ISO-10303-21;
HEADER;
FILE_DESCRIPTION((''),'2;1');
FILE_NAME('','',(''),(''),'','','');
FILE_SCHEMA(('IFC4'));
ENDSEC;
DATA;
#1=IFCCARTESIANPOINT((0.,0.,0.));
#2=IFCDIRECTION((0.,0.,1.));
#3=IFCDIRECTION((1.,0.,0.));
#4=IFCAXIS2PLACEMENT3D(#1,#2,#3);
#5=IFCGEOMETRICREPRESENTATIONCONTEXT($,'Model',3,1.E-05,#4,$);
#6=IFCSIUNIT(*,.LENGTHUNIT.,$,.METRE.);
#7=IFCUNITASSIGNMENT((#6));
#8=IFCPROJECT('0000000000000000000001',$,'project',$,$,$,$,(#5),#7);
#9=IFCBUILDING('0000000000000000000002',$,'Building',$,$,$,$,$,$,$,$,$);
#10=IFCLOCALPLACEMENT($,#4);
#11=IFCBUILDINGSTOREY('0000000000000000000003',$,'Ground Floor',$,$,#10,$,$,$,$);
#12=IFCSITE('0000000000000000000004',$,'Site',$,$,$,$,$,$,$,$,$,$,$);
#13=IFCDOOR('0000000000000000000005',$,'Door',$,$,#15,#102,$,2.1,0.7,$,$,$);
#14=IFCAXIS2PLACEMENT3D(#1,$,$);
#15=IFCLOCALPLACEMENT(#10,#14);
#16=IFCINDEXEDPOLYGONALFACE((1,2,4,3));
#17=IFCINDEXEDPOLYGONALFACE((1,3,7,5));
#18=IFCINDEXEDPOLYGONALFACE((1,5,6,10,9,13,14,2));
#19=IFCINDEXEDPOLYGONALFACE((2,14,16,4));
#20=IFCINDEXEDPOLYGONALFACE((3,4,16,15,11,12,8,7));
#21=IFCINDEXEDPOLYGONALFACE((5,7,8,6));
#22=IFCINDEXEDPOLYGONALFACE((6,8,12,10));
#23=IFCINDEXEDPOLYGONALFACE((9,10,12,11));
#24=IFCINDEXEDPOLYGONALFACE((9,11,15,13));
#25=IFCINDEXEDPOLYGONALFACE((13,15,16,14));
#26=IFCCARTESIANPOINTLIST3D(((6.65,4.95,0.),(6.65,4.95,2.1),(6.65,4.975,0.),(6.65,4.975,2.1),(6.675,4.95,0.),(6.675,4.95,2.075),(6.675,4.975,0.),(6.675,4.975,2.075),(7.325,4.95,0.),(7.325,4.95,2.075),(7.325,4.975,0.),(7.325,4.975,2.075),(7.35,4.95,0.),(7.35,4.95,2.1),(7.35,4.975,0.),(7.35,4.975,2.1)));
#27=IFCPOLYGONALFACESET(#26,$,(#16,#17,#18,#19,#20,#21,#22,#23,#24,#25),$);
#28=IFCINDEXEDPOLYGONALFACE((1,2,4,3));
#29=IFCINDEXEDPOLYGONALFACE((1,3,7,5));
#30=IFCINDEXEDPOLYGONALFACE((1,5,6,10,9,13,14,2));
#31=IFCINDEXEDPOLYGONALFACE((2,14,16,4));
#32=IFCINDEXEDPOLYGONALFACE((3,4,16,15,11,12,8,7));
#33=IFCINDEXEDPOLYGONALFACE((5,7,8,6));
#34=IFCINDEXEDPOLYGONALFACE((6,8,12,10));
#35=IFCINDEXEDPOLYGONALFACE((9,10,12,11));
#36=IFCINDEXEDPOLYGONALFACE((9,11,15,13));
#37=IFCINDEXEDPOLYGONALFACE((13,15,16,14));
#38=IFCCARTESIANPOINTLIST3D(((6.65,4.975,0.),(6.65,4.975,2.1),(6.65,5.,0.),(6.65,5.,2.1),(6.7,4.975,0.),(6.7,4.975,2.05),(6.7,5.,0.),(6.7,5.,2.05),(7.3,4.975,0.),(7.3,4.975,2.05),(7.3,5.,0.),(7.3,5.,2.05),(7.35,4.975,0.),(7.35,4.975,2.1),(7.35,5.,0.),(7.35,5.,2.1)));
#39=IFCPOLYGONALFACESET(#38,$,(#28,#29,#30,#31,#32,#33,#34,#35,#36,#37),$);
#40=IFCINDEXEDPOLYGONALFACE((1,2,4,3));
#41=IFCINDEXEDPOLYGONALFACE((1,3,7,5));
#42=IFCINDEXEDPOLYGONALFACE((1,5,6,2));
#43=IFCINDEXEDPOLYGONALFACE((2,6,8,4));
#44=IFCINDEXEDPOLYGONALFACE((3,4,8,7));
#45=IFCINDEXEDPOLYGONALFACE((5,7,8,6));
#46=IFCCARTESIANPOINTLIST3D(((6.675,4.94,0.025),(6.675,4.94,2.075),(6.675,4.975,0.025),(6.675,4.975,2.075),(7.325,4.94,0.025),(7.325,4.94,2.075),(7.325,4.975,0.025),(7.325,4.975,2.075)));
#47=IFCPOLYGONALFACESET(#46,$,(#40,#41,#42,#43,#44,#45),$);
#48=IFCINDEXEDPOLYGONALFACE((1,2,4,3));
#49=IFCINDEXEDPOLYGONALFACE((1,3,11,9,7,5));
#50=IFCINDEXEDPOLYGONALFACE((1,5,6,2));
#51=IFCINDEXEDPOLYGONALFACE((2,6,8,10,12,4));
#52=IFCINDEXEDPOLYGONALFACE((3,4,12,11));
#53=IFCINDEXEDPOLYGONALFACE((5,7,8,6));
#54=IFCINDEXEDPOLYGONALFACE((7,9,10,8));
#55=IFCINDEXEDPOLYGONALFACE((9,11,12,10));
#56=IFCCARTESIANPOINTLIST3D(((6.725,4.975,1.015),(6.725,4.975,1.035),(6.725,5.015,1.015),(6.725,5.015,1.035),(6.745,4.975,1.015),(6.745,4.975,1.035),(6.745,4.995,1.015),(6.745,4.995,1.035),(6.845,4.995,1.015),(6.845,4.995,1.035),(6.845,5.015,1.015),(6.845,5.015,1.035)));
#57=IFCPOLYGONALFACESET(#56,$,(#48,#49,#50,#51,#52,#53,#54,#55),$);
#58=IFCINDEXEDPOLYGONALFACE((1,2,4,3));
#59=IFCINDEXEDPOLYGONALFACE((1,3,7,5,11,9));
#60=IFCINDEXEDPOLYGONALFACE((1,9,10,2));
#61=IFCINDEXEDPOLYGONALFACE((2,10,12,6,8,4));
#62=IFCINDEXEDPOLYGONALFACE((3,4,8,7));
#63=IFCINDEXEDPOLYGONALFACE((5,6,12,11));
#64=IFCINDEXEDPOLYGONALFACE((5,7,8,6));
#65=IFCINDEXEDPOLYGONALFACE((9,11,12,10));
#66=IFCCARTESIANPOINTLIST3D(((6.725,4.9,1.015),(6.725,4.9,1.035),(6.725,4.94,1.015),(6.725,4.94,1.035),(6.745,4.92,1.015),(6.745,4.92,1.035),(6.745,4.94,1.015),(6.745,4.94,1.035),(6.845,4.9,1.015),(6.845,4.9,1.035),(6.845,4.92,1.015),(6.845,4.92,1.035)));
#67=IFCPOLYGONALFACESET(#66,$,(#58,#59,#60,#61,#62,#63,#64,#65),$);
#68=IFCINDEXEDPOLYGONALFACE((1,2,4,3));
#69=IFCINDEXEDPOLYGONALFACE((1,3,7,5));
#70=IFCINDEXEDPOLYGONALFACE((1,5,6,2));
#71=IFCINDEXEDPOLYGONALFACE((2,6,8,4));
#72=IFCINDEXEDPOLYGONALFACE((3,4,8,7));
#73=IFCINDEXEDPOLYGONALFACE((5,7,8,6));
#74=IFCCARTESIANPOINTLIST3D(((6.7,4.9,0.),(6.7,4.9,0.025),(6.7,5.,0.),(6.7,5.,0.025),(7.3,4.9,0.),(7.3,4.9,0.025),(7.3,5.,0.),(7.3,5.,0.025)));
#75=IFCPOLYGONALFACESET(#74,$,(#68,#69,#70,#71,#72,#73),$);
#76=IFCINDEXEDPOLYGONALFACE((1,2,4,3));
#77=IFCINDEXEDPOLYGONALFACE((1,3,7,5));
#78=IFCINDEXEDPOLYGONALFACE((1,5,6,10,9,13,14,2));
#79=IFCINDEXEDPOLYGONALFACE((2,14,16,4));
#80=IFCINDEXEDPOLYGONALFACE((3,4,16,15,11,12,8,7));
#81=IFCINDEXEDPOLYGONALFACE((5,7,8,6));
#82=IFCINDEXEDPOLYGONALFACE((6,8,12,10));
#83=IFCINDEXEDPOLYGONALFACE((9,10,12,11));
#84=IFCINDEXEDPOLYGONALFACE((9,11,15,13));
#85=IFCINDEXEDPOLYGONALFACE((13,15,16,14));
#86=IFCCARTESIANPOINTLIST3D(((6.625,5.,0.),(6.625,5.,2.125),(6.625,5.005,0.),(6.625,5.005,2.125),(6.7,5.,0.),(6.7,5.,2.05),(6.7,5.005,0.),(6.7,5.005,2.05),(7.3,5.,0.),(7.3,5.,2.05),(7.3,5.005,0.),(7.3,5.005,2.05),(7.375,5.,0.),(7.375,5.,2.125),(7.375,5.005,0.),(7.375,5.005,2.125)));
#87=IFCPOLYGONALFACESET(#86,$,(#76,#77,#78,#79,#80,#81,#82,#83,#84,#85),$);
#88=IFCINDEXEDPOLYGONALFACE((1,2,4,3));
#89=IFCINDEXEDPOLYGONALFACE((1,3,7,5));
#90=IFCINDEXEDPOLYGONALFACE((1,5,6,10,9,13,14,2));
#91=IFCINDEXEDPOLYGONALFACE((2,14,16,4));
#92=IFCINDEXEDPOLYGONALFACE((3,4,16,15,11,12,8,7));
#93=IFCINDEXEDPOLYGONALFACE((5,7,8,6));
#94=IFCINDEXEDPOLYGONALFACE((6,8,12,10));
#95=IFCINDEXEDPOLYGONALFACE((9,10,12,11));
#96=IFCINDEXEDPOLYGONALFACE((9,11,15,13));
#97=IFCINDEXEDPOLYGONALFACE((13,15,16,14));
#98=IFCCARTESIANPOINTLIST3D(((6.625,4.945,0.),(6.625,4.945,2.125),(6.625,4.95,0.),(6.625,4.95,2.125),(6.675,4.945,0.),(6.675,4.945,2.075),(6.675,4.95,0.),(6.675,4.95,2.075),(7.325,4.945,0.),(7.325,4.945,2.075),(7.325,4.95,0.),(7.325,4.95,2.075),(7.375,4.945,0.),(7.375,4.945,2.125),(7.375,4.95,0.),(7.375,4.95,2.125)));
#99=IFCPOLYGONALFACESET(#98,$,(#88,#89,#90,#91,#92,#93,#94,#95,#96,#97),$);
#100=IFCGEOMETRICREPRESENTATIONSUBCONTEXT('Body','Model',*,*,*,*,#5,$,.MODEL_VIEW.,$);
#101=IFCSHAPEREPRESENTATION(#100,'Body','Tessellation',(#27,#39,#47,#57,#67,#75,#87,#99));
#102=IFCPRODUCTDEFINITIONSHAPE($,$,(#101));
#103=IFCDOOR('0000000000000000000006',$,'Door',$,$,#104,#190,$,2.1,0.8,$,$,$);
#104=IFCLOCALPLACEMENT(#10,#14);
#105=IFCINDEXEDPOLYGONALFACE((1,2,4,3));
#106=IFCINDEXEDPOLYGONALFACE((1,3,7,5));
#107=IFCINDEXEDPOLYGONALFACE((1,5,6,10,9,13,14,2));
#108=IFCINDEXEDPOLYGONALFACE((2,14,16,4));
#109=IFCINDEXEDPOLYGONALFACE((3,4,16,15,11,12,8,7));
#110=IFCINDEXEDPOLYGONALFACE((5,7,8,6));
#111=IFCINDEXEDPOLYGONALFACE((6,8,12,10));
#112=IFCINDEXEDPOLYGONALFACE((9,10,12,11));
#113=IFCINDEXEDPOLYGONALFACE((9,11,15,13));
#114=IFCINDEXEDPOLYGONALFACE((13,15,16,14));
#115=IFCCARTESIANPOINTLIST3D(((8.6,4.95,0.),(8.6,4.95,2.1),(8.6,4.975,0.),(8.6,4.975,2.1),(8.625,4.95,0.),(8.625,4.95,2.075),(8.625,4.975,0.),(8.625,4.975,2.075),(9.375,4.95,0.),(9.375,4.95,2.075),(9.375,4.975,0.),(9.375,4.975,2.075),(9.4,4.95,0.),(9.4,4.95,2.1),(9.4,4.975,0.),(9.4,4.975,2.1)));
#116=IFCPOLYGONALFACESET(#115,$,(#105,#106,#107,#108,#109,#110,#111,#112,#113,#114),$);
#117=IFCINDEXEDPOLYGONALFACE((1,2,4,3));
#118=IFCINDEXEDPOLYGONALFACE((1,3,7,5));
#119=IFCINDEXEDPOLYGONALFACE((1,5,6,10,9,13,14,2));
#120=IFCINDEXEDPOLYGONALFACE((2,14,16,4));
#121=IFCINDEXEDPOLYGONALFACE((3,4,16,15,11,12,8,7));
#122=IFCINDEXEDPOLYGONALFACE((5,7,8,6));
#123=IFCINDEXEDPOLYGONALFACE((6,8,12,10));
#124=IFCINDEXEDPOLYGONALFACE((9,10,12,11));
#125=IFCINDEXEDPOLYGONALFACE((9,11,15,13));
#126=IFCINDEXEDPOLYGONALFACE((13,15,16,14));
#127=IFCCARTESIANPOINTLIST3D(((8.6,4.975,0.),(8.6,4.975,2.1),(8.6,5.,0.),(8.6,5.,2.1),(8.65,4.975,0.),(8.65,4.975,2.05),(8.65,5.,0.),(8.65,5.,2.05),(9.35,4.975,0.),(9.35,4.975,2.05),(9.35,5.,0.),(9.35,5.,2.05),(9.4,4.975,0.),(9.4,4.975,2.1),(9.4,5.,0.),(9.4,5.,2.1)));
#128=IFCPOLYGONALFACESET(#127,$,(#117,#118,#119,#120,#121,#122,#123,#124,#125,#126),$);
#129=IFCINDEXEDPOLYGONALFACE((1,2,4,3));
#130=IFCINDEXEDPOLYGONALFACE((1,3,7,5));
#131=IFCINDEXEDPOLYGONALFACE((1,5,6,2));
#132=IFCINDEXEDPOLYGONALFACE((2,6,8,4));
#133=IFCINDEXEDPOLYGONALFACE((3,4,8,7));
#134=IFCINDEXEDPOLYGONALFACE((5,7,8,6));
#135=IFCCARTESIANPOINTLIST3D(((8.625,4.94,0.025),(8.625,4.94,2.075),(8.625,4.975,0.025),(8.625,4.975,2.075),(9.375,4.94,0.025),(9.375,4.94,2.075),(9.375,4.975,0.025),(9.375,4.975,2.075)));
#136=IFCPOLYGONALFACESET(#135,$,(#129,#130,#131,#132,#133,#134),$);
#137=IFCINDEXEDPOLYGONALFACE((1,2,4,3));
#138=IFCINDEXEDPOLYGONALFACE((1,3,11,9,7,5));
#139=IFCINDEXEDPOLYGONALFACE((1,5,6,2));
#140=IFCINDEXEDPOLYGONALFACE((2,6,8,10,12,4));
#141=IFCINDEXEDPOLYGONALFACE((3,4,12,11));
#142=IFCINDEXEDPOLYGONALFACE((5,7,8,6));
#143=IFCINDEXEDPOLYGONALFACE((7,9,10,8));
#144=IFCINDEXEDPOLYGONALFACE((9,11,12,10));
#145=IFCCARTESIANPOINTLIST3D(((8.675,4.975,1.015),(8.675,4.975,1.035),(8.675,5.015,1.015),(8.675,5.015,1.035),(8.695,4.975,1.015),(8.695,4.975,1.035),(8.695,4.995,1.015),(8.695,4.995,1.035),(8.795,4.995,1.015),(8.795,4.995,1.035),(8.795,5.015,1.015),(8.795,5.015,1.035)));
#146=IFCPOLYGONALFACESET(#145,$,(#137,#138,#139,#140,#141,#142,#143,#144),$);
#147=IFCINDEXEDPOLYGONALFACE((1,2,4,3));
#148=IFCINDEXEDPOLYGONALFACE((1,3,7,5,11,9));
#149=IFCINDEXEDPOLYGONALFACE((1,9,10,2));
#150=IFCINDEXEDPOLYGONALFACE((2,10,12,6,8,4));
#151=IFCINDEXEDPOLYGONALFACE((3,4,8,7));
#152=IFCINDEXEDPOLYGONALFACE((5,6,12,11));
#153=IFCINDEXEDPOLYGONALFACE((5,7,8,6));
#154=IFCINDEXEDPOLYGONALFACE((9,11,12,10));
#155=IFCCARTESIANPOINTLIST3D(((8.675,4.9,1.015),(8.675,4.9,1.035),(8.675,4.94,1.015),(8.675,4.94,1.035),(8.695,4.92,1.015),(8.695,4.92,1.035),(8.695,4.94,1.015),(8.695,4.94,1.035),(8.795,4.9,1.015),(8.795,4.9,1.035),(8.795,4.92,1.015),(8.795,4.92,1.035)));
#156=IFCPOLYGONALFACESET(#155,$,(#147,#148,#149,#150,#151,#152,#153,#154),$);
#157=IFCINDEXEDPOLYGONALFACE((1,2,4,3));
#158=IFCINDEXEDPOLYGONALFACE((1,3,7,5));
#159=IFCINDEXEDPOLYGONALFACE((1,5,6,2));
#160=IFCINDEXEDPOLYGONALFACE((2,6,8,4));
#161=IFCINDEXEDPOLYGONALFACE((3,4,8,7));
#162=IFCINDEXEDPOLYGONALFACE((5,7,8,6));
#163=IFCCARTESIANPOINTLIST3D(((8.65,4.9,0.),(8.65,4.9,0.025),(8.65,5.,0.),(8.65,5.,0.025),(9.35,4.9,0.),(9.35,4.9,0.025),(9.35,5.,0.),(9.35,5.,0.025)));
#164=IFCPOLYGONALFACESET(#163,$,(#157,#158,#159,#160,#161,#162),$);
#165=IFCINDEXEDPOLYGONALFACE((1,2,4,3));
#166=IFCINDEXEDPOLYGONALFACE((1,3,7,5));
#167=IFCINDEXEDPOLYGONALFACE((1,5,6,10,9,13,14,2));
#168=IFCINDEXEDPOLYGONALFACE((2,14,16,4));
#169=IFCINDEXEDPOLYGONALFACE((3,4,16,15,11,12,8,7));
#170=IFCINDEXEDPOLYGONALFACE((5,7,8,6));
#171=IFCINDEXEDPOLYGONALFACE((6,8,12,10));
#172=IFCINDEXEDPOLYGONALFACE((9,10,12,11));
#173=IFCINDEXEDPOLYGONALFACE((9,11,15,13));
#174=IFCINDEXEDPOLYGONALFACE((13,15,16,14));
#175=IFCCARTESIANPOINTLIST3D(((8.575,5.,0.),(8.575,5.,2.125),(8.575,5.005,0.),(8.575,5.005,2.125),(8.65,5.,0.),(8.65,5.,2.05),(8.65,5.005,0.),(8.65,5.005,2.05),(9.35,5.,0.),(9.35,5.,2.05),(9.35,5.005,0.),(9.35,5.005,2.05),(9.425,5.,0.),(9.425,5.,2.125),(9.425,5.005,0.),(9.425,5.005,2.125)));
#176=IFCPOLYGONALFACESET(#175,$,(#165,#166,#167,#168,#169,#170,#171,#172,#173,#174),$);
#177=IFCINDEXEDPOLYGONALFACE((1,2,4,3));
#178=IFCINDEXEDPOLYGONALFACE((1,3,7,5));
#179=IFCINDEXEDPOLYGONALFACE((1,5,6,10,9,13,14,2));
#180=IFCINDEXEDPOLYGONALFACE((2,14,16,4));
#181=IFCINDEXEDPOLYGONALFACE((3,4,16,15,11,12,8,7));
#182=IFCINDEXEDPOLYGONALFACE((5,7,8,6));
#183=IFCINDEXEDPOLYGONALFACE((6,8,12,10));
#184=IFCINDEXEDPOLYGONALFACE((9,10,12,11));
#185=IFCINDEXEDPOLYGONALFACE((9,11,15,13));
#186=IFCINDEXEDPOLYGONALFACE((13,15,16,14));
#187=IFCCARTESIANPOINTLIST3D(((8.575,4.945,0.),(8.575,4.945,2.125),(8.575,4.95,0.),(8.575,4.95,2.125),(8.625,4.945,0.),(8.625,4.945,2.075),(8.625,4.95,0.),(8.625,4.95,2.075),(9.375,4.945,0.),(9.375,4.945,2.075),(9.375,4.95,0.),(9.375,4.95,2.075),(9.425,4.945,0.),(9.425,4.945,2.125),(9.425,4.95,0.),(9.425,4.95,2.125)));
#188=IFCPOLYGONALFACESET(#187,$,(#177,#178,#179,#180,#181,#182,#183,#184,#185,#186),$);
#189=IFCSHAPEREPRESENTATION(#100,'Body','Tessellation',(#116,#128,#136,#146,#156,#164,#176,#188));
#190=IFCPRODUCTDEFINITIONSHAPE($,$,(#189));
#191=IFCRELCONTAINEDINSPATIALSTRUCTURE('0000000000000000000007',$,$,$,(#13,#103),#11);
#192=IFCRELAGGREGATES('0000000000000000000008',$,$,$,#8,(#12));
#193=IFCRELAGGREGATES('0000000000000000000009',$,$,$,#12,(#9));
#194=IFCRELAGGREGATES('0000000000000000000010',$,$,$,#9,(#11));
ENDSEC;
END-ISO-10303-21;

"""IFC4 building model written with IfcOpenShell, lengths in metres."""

from ifc_helpers import new_model, si_unit, frame, origin_with_axes, place, context, subcontext, project, spatial, line, indexed_curve, outline, extrude, element, save


model = new_model("IFC4")

# Units and contexts
model_context = context("Model", 3, precision=1e-05, world=origin_with_axes())
body_context = subcontext(model_context, "Body", "Model", "MODEL_VIEW")
ifc_project = project(units=[si_unit("LENGTHUNIT", "METRE")], contexts=[model_context])

# Site, building, storey
site = spatial("IfcSite", under=ifc_project, Name="Site")
building = spatial("IfcBuilding", under=site, Name="Building")
storey_placement = place(None, origin_with_axes())
storey = spatial("IfcBuildingStorey", under=building, at=storey_placement, Name="Ground Floor")

# Doors
door_1_placement = place(storey_placement, frame((7.35, 5.0, 0.0), z_axis=(0.0, 0.0, 1.0), x_axis=(-1.0, 0.0, 0.0)))
element("IfcDoor", 1, at=door_1_placement, inside=storey, Name="Door", OverallHeight=2.1, OverallWidth=0.7, context=body_context, shape_type="SweptSolid", body=[
    extrude(outline(indexed_curve([(0.0, 0.0), (0.0, 2.1), (0.7, 2.1), (0.7, 0.0), (0.675, 0.0), (0.675, 2.075), (0.025, 2.075), (0.025, 0.0)], segments=[line(1, 2, 3, 4, 5, 6, 7, 8, 1)])), frame((0.0, 0.025, 0.0), z_axis=(0.0, -1.0, 0.0), x_axis=(1.0, 0.0, 0.0)), (0.0, 0.0, -1.0), 0.025),
    extrude(outline(indexed_curve([(0.0, 0.0), (0.0, 2.1), (0.7, 2.1), (0.7, 0.0), (0.65, 0.0), (0.65, 2.05), (0.05, 2.05), (0.05, 0.0)], segments=[line(1, 2, 3, 4, 5, 6, 7, 8, 1)])), frame((0.0, 0.0, 0.0), z_axis=(0.0, -1.0, 0.0), x_axis=(1.0, 0.0, 0.0)), (0.0, 0.0, -1.0), 0.025),
    extrude(outline(indexed_curve([(0.0, 0.0), (0.65, 0.0), (0.65, 0.035), (0.0, 0.035)], segments=[line(1, 2, 3, 4, 1)])), frame((0.025, 0.025, 0.025), z_axis=(0.0, 0.0, 1.0), x_axis=(1.0, 0.0, 0.0)), (0.0, 0.0, 1.0), 2.05),
    extrude(outline(indexed_curve([(0.0, 0.0), (0.0, -0.04), (-0.12, -0.04), (-0.12, -0.02), (-0.02, -0.02), (-0.02, 0.0)], segments=[line(1, 2, 3, 4, 5, 6, 1)])), frame((0.625, 0.025, 1.015), z_axis=(0.0, 0.0, 1.0), x_axis=(1.0, 0.0, 0.0)), (0.0, 0.0, 1.0), 0.02),
    extrude(outline(indexed_curve([(0.0, 0.0), (0.0, 0.04), (-0.12, 0.04), (-0.12, 0.02), (-0.02, 0.02), (-0.02, 0.0)], segments=[line(1, 2, 3, 4, 5, 6, 1)])), frame((0.625, 0.06, 1.015), z_axis=(0.0, 0.0, 1.0), x_axis=(1.0, 0.0, 0.0)), (0.0, 0.0, 1.0), 0.02),
    extrude(outline(indexed_curve([(0.0, 0.0), (0.6, 0.0), (0.6, 0.1), (0.0, 0.1)], segments=[line(1, 2, 3, 4, 1)])), frame((0.05, 0.0, 0.0), z_axis=(0.0, 0.0, 1.0), x_axis=(1.0, 0.0, 0.0)), (0.0, 0.0, 1.0), 0.025),
    extrude(outline(indexed_curve([(0.0, 0.0), (0.0, 2.125), (0.75, 2.125), (0.75, 0.0), (0.675, 0.0), (0.675, 2.05), (0.075, 2.05), (0.075, 0.0)], segments=[line(1, 2, 3, 4, 5, 6, 7, 8, 1)])), frame((-0.025, -0.005, 0.0), z_axis=(0.0, -1.0, 0.0), x_axis=(1.0, 0.0, 0.0)), (0.0, 0.0, -1.0), 0.005),
    extrude(outline(indexed_curve([(0.0, 0.0), (0.0, 2.125), (0.75, 2.125), (0.75, 0.0), (0.7, 0.0), (0.7, 2.075), (0.05, 2.075), (0.05, 0.0)], segments=[line(1, 2, 3, 4, 5, 6, 7, 8, 1)])), frame((-0.025, 0.05, 0.0), z_axis=(0.0, -1.0, 0.0), x_axis=(1.0, 0.0, 0.0)), (0.0, 0.0, -1.0), 0.005),
])
door_2_placement = place(storey_placement, frame((9.4, 5.0, 0.0), z_axis=(0.0, 0.0, 1.0), x_axis=(-1.0, 0.0, 0.0)))
element("IfcDoor", 2, at=door_2_placement, inside=storey, Name="Door", OverallHeight=2.1, OverallWidth=0.8, context=body_context, shape_type="SweptSolid", body=[
    extrude(outline(indexed_curve([(0.0, 0.0), (0.0, 2.1), (0.8, 2.1), (0.8, 0.0), (0.775, 0.0), (0.775, 2.075), (0.025, 2.075), (0.025, 0.0)], segments=[line(1, 2, 3, 4, 5, 6, 7, 8, 1)])), frame((0.0, 0.025, 0.0), z_axis=(0.0, -1.0, 0.0), x_axis=(1.0, 0.0, 0.0)), (0.0, 0.0, -1.0), 0.025),
    extrude(outline(indexed_curve([(0.0, 0.0), (0.0, 2.1), (0.8, 2.1), (0.8, 0.0), (0.75, 0.0), (0.75, 2.05), (0.05, 2.05), (0.05, 0.0)], segments=[line(1, 2, 3, 4, 5, 6, 7, 8, 1)])), frame((0.0, 0.0, 0.0), z_axis=(0.0, -1.0, 0.0), x_axis=(1.0, 0.0, 0.0)), (0.0, 0.0, -1.0), 0.025),
    extrude(outline(indexed_curve([(0.0, 0.0), (0.75, 0.0), (0.75, 0.035), (0.0, 0.035)], segments=[line(1, 2, 3, 4, 1)])), frame((0.025, 0.025, 0.025), z_axis=(0.0, 0.0, 1.0), x_axis=(1.0, 0.0, 0.0)), (0.0, 0.0, 1.0), 2.05),
    extrude(outline(indexed_curve([(0.0, 0.0), (0.0, -0.04), (-0.12, -0.04), (-0.12, -0.02), (-0.02, -0.02), (-0.02, 0.0)], segments=[line(1, 2, 3, 4, 5, 6, 1)])), frame((0.725, 0.025, 1.015), z_axis=(0.0, 0.0, 1.0), x_axis=(1.0, 0.0, 0.0)), (0.0, 0.0, 1.0), 0.02),
    extrude(outline(indexed_curve([(0.0, 0.0), (0.0, 0.04), (-0.12, 0.04), (-0.12, 0.02), (-0.02, 0.02), (-0.02, 0.0)], segments=[line(1, 2, 3, 4, 5, 6, 1)])), frame((0.725, 0.06, 1.015), z_axis=(0.0, 0.0, 1.0), x_axis=(1.0, 0.0, 0.0)), (0.0, 0.0, 1.0), 0.02),
    extrude(outline(indexed_curve([(0.0, 0.0), (0.7, 0.0), (0.7, 0.1), (0.0, 0.1)], segments=[line(1, 2, 3, 4, 1)])), frame((0.05, 0.0, 0.0), z_axis=(0.0, 0.0, 1.0), x_axis=(1.0, 0.0, 0.0)), (0.0, 0.0, 1.0), 0.025),
    extrude(outline(indexed_curve([(0.0, 0.0), (0.0, 2.125), (0.85, 2.125), (0.85, 0.0), (0.775, 0.0), (0.775, 2.05), (0.075, 2.05), (0.075, 0.0)], segments=[line(1, 2, 3, 4, 5, 6, 7, 8, 1)])), frame((-0.025, -0.005, 0.0), z_axis=(0.0, -1.0, 0.0), x_axis=(1.0, 0.0, 0.0)), (0.0, 0.0, -1.0), 0.005),
    extrude(outline(indexed_curve([(0.0, 0.0), (0.0, 2.125), (0.85, 2.125), (0.85, 0.0), (0.8, 0.0), (0.8, 2.075), (0.05, 2.075), (0.05, 0.0)], segments=[line(1, 2, 3, 4, 5, 6, 7, 8, 1)])), frame((-0.025, 0.05, 0.0), z_axis=(0.0, -1.0, 0.0), x_axis=(1.0, 0.0, 0.0)), (0.0, 0.0, -1.0), 0.005),
])

save(model, "model.ifc")
